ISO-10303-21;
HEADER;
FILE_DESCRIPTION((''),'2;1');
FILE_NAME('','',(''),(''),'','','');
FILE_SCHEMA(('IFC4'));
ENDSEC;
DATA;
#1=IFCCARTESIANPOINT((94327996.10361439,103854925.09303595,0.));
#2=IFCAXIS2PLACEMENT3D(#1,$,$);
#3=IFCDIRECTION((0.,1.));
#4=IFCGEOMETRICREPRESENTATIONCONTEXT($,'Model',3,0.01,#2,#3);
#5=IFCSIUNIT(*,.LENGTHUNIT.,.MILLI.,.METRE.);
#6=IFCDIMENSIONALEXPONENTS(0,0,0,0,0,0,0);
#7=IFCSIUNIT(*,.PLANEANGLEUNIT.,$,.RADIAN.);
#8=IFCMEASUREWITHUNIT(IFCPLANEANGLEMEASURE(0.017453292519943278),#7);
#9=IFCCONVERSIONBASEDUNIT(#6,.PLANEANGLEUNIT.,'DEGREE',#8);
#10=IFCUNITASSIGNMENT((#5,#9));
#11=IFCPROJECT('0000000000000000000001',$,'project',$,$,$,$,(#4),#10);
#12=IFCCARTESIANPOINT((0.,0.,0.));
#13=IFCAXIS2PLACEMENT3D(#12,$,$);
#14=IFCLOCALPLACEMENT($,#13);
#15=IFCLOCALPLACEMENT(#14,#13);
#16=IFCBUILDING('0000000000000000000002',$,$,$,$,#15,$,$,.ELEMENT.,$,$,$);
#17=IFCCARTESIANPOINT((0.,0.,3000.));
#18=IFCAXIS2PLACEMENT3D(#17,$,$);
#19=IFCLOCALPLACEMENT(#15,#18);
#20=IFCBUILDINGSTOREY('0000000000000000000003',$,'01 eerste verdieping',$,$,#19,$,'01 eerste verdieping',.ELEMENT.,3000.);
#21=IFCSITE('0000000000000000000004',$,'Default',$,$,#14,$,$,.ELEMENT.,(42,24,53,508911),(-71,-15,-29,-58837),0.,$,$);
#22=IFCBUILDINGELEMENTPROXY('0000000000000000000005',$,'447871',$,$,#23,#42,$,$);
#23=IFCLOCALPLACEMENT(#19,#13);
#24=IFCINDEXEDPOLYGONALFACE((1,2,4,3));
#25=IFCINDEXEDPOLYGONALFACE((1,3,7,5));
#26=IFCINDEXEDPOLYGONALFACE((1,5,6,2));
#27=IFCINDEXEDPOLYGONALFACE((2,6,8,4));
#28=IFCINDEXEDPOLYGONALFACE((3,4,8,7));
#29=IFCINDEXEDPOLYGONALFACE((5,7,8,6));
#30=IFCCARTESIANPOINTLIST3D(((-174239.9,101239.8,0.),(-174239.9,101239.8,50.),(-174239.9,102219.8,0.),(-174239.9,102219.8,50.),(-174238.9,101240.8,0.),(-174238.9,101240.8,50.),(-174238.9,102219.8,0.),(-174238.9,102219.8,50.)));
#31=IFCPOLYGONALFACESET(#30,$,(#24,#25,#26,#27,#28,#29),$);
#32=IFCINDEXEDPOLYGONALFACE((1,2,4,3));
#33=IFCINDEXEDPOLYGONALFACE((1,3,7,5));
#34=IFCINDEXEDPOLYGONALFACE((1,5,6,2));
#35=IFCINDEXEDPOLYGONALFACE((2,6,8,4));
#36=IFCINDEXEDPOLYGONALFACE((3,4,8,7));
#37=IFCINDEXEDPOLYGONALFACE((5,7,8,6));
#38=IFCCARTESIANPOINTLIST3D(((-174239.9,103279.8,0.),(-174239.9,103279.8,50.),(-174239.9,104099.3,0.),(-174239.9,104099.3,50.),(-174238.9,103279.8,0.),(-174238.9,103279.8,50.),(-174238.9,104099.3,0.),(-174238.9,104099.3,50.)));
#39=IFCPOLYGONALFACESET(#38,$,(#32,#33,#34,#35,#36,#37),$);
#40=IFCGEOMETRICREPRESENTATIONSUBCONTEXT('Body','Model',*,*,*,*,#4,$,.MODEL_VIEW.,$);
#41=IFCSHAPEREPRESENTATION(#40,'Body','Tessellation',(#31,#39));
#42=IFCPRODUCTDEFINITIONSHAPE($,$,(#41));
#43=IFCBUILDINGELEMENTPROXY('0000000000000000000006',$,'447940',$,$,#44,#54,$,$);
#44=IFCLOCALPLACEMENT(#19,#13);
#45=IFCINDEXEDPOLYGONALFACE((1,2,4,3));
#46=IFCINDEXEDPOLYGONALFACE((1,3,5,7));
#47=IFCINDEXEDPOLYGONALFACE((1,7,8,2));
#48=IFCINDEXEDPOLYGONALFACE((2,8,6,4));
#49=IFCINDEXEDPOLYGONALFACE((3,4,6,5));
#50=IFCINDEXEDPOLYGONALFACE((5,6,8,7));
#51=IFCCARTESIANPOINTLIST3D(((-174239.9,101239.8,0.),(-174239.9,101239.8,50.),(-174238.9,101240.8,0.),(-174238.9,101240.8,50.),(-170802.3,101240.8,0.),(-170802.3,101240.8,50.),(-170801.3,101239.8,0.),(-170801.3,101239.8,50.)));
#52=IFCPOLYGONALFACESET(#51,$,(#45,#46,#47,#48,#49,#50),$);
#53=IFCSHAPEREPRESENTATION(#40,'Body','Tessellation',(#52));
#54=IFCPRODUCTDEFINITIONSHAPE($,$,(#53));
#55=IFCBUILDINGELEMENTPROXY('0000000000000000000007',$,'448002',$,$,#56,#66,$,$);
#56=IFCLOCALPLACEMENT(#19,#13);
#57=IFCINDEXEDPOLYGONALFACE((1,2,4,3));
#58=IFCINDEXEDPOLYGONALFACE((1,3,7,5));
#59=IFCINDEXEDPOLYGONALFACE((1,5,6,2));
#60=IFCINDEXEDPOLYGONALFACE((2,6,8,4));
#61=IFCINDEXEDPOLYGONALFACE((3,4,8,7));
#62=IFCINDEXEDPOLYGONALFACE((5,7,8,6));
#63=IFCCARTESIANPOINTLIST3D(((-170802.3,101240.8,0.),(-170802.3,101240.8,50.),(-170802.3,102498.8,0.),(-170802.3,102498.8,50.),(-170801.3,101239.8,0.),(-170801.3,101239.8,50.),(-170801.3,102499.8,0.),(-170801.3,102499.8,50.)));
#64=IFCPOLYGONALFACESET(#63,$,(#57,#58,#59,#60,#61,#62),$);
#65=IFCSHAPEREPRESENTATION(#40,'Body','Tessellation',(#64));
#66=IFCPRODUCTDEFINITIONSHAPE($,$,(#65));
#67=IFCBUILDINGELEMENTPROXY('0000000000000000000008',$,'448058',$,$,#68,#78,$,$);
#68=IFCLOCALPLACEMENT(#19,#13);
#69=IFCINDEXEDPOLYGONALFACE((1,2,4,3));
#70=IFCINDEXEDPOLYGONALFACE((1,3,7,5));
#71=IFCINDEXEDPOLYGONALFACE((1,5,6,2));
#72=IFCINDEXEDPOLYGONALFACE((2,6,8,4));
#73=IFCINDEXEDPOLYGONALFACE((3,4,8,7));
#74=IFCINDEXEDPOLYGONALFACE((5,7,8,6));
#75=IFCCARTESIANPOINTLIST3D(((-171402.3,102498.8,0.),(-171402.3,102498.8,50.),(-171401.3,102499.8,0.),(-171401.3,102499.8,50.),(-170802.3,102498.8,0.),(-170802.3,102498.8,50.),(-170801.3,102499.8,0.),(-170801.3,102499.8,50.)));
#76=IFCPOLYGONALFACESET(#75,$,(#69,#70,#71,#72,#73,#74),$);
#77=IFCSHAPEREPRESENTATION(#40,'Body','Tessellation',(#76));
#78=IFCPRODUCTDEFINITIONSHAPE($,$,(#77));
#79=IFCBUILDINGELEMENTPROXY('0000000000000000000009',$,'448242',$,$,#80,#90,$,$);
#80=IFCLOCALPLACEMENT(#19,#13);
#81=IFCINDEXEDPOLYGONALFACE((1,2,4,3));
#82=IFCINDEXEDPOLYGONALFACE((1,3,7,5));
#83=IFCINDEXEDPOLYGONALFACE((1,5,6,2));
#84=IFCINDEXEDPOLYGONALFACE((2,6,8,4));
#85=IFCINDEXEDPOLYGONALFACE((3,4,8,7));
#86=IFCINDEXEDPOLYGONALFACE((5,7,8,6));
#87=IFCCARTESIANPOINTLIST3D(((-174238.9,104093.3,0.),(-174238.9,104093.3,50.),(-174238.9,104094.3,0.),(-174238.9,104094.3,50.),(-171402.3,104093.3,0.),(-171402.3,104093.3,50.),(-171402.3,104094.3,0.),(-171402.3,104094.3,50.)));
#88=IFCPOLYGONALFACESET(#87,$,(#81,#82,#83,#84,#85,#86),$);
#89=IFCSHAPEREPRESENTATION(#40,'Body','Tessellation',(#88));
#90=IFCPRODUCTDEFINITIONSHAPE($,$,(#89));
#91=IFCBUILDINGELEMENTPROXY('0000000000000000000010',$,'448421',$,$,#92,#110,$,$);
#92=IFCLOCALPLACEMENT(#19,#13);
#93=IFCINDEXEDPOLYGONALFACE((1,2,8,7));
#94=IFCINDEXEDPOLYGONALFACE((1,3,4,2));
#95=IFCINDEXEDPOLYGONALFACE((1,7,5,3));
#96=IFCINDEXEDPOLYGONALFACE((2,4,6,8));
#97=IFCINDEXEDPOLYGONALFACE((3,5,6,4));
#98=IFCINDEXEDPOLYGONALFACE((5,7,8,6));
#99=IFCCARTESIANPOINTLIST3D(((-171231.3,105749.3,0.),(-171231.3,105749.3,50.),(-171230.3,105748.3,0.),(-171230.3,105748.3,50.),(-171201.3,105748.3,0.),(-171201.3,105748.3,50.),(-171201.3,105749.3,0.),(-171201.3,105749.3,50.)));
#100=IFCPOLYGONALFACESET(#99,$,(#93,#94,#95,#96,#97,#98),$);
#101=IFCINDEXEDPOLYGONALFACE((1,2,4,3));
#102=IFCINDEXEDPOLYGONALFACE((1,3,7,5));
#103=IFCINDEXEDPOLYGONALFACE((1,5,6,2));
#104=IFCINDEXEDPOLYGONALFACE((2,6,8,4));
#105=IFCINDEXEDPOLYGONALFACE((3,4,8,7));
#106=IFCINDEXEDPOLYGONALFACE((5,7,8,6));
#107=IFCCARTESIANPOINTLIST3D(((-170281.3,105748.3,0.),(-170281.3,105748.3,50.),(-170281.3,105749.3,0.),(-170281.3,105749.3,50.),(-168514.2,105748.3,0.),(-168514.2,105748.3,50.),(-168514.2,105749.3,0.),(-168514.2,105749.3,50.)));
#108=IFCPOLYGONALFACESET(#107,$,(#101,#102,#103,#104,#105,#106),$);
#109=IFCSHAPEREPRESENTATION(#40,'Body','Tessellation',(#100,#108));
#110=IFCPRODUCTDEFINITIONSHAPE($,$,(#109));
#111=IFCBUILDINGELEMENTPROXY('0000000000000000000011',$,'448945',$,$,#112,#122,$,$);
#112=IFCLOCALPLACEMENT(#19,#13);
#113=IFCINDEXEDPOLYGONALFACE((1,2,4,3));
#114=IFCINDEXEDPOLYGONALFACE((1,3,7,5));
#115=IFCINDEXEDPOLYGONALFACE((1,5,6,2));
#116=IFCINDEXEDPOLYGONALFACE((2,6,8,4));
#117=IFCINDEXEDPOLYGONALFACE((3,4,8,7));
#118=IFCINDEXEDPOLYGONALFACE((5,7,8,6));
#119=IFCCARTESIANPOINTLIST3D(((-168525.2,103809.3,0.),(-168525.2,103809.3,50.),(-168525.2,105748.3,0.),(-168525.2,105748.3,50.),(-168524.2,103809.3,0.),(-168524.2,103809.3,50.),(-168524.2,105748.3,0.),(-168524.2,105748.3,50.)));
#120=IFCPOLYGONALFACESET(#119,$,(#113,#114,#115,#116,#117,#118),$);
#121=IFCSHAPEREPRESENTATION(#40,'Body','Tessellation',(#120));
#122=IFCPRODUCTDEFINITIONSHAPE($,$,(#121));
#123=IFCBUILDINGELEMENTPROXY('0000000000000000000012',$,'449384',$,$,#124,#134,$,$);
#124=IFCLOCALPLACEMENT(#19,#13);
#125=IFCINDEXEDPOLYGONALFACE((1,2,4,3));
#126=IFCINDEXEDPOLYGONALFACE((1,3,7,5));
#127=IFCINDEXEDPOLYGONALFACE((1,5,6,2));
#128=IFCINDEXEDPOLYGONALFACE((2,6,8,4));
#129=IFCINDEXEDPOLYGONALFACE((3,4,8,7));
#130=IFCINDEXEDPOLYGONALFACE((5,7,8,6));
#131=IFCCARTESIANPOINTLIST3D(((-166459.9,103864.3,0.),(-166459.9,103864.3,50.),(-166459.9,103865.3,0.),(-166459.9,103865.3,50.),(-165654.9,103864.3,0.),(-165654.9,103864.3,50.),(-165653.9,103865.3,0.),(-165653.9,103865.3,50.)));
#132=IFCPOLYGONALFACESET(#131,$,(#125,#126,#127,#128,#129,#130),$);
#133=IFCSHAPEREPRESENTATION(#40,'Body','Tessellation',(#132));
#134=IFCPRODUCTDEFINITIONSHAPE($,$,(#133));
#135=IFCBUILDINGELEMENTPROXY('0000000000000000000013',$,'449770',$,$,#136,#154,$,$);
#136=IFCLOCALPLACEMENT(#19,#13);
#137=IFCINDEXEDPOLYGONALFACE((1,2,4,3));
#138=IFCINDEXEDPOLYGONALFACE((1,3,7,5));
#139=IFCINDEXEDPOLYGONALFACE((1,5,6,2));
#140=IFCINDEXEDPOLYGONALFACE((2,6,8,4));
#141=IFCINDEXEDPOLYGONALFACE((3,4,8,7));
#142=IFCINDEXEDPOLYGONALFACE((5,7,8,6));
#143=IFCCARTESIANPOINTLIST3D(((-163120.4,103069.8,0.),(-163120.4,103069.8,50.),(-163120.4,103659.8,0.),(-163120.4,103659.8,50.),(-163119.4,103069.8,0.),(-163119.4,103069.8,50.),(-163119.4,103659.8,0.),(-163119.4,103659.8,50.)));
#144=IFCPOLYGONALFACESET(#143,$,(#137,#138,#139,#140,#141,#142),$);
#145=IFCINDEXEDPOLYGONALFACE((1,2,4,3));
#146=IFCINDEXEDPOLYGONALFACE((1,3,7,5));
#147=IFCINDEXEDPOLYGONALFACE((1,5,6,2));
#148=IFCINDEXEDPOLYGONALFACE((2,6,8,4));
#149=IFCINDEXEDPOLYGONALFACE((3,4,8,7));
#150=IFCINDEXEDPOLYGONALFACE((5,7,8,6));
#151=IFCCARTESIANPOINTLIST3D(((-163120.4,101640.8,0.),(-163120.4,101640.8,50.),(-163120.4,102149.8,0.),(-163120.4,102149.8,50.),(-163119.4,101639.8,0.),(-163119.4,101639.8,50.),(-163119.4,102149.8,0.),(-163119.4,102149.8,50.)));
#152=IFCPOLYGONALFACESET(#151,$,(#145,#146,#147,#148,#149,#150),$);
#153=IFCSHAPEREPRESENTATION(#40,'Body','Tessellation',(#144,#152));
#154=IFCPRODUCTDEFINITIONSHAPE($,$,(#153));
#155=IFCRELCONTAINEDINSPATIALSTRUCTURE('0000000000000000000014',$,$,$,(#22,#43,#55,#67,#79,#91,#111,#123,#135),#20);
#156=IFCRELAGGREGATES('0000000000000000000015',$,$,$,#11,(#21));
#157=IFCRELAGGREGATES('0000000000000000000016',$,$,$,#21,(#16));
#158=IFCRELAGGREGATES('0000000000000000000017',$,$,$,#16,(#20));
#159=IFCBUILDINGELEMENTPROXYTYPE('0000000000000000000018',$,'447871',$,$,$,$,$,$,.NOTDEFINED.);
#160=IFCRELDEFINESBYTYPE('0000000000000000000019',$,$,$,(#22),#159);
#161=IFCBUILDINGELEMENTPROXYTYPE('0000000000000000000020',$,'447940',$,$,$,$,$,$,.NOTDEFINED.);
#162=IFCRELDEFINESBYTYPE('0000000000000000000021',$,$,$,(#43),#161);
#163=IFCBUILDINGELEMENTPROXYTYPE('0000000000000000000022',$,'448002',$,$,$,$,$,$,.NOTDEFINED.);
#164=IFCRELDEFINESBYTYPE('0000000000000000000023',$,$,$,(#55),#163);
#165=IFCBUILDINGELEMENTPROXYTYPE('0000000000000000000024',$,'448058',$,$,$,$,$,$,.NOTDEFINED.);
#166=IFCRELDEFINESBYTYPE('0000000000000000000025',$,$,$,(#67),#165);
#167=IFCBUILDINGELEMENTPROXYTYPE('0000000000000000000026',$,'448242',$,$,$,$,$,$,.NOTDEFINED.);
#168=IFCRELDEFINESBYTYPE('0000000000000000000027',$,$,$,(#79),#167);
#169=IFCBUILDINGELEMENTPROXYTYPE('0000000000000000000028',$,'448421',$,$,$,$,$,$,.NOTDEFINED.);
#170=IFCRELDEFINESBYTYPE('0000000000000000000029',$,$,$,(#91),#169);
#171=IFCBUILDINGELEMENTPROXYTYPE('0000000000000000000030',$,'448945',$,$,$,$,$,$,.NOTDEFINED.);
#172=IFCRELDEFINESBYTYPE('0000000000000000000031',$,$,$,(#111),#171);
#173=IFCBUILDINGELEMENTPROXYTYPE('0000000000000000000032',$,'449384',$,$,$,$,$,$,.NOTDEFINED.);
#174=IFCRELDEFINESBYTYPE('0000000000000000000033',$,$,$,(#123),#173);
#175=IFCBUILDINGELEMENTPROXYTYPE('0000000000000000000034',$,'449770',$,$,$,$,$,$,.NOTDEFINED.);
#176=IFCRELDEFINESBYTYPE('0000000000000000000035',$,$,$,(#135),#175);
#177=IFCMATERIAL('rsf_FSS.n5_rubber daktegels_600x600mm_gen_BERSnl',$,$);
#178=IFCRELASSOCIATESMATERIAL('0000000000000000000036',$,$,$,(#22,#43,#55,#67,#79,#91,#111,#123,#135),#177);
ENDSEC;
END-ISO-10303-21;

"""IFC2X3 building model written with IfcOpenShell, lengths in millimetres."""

from ifc_helpers import new_model, entity, si_unit, converted_unit, direction, frame, frame_2d, origin, origin_2d_with_axis, place, context, subcontext, project, spatial, polyline, rectangle, outline, extrude, material, type_object, element, save


model = new_model("IFC2X3")

# Units and contexts
model_context = context("Model", 3, precision=0.01, world=frame((94327996.10361439, 103854925.09303595, 0.0)), true_north=direction((0.0, 1.0)))
body_context = subcontext(model_context, "Body", "Model", "MODEL_VIEW")
ifc_project = project(units=[si_unit("LENGTHUNIT", "METRE", prefix="MILLI"), converted_unit("PLANEANGLEUNIT", "DEGREE", entity("IfcPlaneAngleMeasure", 0.017453292519943278), si_unit("PLANEANGLEUNIT", "RADIAN"), dimensions=[0, 0, 0, 0, 0, 0, 0])], contexts=[model_context])

# Site, building, storey
site_placement = place(None, origin())
site = spatial("IfcSite", under=ifc_project, at=site_placement, Name="Default", CompositionType="ELEMENT", RefLatitude=(42, 24, 53, 508911), RefLongitude=(-71, -15, -29, -58837), RefElevation=0.0)
building_placement = place(site_placement, origin())
building = spatial("IfcBuilding", under=site, at=building_placement, CompositionType="ELEMENT")
storey_placement = place(building_placement, frame((0.0, 0.0, 3000.0)))
storey = spatial("IfcBuildingStorey", under=building, at=storey_placement, Name="01 eerste verdieping", LongName="01 eerste verdieping", CompositionType="ELEMENT", Elevation=3000.0)

# Building element proxies
ifc_material = material(Name="rsf_FSS.n5_rubber daktegels_600x600mm_gen_BERSnl")
building_element_proxy_type_1 = type_object("IfcBuildingElementProxyType", Name="447871", PredefinedType="NOTDEFINED")
proxy_1_placement = place(storey_placement, origin())
element("IfcBuildingElementProxy", 1, at=proxy_1_placement, inside=storey, type_object=building_element_proxy_type_1, material=ifc_material, Name="447871", context=body_context, shape_type="SweptSolid", body=[
    extrude(outline(polyline([(-489.7, -0.5), (490.2, -0.5), (489.2, 0.5), (-489.7, 0.5), (-489.7, -0.5)])), frame((-174239.4, 101730.0, 0.0), z_axis=(0.0, 0.0, 1.0), x_axis=(0.0, -1.0, 0.0)), (0.0, 0.0, 1.0), 50.0),
    extrude(rectangle(XDim=819.5, YDim=1.0, at=frame_2d((0.0, 0.0), x_axis=(1.0, 0.0))), frame((-174239.4, 103689.5, 0.0), z_axis=(0.0, 0.0, 1.0), x_axis=(0.0, -1.0, 0.0)), (0.0, 0.0, 1.0), 50.0),
])
building_element_proxy_type_2 = type_object("IfcBuildingElementProxyType", Name="447940", PredefinedType="NOTDEFINED")
proxy_2_placement = place(storey_placement, origin())
element("IfcBuildingElementProxy", 2, at=proxy_2_placement, inside=storey, type_object=building_element_proxy_type_2, material=ifc_material, Name="447940", context=body_context, shape_type="SweptSolid", body=[
    extrude(outline(polyline([(-1719.3, -0.5), (1719.3, -0.5), (1718.3, 0.5), (-1718.3, 0.5), (-1719.3, -0.5)])), frame((-172520.6, 101240.3, 0.0)), (0.0, 0.0, 1.0), 50.0),
])
building_element_proxy_type_3 = type_object("IfcBuildingElementProxyType", Name="448002", PredefinedType="NOTDEFINED")
proxy_3_placement = place(storey_placement, origin())
element("IfcBuildingElementProxy", 3, at=proxy_3_placement, inside=storey, type_object=building_element_proxy_type_3, material=ifc_material, Name="448002", context=body_context, shape_type="SweptSolid", body=[
    extrude(outline(polyline([(-630.0, -0.5), (630.0, -0.5), (629.0, 0.5), (-629.0, 0.5), (-630.0, -0.5)])), frame((-170801.8, 101869.8, 0.0), z_axis=(0.0, 0.0, 1.0), x_axis=(0.0, 1.0, 0.0)), (0.0, 0.0, 1.0), 50.0),
])
building_element_proxy_type_4 = type_object("IfcBuildingElementProxyType", Name="448058", PredefinedType="NOTDEFINED")
proxy_4_placement = place(storey_placement, origin())
element("IfcBuildingElementProxy", 4, at=proxy_4_placement, inside=storey, type_object=building_element_proxy_type_4, material=ifc_material, Name="448058", context=body_context, shape_type="SweptSolid", body=[
    extrude(outline(polyline([(-300.5, -0.5), (299.5, -0.5), (300.5, 0.5), (-299.5, 0.5), (-300.5, -0.5)])), frame((-171101.8, 102499.3, 0.0), z_axis=(0.0, 0.0, 1.0), x_axis=(-1.0, 0.0, 0.0)), (0.0, 0.0, 1.0), 50.0),
])
building_element_proxy_type_5 = type_object("IfcBuildingElementProxyType", Name="448242", PredefinedType="NOTDEFINED")
proxy_5_placement = place(storey_placement, origin())
element("IfcBuildingElementProxy", 5, at=proxy_5_placement, inside=storey, type_object=building_element_proxy_type_5, material=ifc_material, Name="448242", context=body_context, shape_type="SweptSolid", body=[
    extrude(rectangle(XDim=2836.6, YDim=1.0, at=frame_2d((0.0, 0.0), x_axis=(1.0, 0.0))), frame((-172820.6, 104093.8, 0.0), z_axis=(0.0, 0.0, 1.0), x_axis=(-1.0, 0.0, 0.0)), (0.0, 0.0, 1.0), 50.0),
])
building_element_proxy_type_6 = type_object("IfcBuildingElementProxyType", Name="448421", PredefinedType="NOTDEFINED")
proxy_6_placement = place(storey_placement, origin())
element("IfcBuildingElementProxy", 6, at=proxy_6_placement, inside=storey, type_object=building_element_proxy_type_6, material=ifc_material, Name="448421", context=body_context, shape_type="SweptSolid", body=[
    extrude(outline(polyline([(-14.7, -0.5), (15.2, -0.5), (14.2, 0.5), (-14.7, 0.5), (-14.7, -0.5)])), frame((-171216.0, 105748.8, 0.0), z_axis=(0.0, 0.0, 1.0), x_axis=(-1.0, 0.0, 0.0)), (0.0, 0.0, 1.0), 50.0),
    extrude(rectangle(XDim=1767.1, YDim=1.0, at=origin_2d_with_axis()), frame((-169397.7, 105748.8, 0.0), z_axis=(0.0, 0.0, 1.0), x_axis=(-1.0, 0.0, 0.0)), (0.0, 0.0, 1.0), 50.0),
])
building_element_proxy_type_7 = type_object("IfcBuildingElementProxyType", Name="448945", PredefinedType="NOTDEFINED")
proxy_7_placement = place(storey_placement, origin())
element("IfcBuildingElementProxy", 7, at=proxy_7_placement, inside=storey, type_object=building_element_proxy_type_7, material=ifc_material, Name="448945", context=body_context, shape_type="SweptSolid", body=[
    extrude(rectangle(XDim=1939.0, YDim=1.0, at=frame_2d((0.0, 0.0), x_axis=(1.0, 0.0))), frame((-168524.7, 104778.8, 0.0), z_axis=(0.0, 0.0, 1.0), x_axis=(0.0, 1.0, 0.0)), (0.0, 0.0, 1.0), 50.0),
])
building_element_proxy_type_8 = type_object("IfcBuildingElementProxyType", Name="449384", PredefinedType="NOTDEFINED")
proxy_8_placement = place(storey_placement, origin())
element("IfcBuildingElementProxy", 8, at=proxy_8_placement, inside=storey, type_object=building_element_proxy_type_8, material=ifc_material, Name="449384", context=body_context, shape_type="SweptSolid", body=[
    extrude(outline(polyline([(-402.7, -0.5), (402.3, -0.5), (403.3, 0.5), (-402.7, 0.5), (-402.7, -0.5)])), frame((-166057.1, 103864.8, 0.0)), (0.0, 0.0, 1.0), 50.0),
])
building_element_proxy_type_9 = type_object("IfcBuildingElementProxyType", Name="449770", PredefinedType="NOTDEFINED")
proxy_9_placement = place(storey_placement, origin())
element("IfcBuildingElementProxy", 9, at=proxy_9_placement, inside=storey, type_object=building_element_proxy_type_9, material=ifc_material, Name="449770", context=body_context, shape_type="SweptSolid", body=[
    extrude(rectangle(XDim=590.0, YDim=1.0, at=frame_2d((0.0, 0.0), x_axis=(1.0, 0.0))), frame((-163119.9, 103364.8, 0.0), z_axis=(0.0, 0.0, 1.0), x_axis=(0.0, 1.0, 0.0)), (0.0, 0.0, 1.0), 50.0),
    extrude(outline(polyline([(-255.2, -0.5), (254.7, -0.5), (254.7, 0.5), (-254.2, 0.5), (-255.2, -0.5)])), frame((-163119.9, 101895.0, 0.0), z_axis=(0.0, 0.0, 1.0), x_axis=(0.0, 1.0, 0.0)), (0.0, 0.0, 1.0), 50.0),
])

save(model, "model.ifc")
